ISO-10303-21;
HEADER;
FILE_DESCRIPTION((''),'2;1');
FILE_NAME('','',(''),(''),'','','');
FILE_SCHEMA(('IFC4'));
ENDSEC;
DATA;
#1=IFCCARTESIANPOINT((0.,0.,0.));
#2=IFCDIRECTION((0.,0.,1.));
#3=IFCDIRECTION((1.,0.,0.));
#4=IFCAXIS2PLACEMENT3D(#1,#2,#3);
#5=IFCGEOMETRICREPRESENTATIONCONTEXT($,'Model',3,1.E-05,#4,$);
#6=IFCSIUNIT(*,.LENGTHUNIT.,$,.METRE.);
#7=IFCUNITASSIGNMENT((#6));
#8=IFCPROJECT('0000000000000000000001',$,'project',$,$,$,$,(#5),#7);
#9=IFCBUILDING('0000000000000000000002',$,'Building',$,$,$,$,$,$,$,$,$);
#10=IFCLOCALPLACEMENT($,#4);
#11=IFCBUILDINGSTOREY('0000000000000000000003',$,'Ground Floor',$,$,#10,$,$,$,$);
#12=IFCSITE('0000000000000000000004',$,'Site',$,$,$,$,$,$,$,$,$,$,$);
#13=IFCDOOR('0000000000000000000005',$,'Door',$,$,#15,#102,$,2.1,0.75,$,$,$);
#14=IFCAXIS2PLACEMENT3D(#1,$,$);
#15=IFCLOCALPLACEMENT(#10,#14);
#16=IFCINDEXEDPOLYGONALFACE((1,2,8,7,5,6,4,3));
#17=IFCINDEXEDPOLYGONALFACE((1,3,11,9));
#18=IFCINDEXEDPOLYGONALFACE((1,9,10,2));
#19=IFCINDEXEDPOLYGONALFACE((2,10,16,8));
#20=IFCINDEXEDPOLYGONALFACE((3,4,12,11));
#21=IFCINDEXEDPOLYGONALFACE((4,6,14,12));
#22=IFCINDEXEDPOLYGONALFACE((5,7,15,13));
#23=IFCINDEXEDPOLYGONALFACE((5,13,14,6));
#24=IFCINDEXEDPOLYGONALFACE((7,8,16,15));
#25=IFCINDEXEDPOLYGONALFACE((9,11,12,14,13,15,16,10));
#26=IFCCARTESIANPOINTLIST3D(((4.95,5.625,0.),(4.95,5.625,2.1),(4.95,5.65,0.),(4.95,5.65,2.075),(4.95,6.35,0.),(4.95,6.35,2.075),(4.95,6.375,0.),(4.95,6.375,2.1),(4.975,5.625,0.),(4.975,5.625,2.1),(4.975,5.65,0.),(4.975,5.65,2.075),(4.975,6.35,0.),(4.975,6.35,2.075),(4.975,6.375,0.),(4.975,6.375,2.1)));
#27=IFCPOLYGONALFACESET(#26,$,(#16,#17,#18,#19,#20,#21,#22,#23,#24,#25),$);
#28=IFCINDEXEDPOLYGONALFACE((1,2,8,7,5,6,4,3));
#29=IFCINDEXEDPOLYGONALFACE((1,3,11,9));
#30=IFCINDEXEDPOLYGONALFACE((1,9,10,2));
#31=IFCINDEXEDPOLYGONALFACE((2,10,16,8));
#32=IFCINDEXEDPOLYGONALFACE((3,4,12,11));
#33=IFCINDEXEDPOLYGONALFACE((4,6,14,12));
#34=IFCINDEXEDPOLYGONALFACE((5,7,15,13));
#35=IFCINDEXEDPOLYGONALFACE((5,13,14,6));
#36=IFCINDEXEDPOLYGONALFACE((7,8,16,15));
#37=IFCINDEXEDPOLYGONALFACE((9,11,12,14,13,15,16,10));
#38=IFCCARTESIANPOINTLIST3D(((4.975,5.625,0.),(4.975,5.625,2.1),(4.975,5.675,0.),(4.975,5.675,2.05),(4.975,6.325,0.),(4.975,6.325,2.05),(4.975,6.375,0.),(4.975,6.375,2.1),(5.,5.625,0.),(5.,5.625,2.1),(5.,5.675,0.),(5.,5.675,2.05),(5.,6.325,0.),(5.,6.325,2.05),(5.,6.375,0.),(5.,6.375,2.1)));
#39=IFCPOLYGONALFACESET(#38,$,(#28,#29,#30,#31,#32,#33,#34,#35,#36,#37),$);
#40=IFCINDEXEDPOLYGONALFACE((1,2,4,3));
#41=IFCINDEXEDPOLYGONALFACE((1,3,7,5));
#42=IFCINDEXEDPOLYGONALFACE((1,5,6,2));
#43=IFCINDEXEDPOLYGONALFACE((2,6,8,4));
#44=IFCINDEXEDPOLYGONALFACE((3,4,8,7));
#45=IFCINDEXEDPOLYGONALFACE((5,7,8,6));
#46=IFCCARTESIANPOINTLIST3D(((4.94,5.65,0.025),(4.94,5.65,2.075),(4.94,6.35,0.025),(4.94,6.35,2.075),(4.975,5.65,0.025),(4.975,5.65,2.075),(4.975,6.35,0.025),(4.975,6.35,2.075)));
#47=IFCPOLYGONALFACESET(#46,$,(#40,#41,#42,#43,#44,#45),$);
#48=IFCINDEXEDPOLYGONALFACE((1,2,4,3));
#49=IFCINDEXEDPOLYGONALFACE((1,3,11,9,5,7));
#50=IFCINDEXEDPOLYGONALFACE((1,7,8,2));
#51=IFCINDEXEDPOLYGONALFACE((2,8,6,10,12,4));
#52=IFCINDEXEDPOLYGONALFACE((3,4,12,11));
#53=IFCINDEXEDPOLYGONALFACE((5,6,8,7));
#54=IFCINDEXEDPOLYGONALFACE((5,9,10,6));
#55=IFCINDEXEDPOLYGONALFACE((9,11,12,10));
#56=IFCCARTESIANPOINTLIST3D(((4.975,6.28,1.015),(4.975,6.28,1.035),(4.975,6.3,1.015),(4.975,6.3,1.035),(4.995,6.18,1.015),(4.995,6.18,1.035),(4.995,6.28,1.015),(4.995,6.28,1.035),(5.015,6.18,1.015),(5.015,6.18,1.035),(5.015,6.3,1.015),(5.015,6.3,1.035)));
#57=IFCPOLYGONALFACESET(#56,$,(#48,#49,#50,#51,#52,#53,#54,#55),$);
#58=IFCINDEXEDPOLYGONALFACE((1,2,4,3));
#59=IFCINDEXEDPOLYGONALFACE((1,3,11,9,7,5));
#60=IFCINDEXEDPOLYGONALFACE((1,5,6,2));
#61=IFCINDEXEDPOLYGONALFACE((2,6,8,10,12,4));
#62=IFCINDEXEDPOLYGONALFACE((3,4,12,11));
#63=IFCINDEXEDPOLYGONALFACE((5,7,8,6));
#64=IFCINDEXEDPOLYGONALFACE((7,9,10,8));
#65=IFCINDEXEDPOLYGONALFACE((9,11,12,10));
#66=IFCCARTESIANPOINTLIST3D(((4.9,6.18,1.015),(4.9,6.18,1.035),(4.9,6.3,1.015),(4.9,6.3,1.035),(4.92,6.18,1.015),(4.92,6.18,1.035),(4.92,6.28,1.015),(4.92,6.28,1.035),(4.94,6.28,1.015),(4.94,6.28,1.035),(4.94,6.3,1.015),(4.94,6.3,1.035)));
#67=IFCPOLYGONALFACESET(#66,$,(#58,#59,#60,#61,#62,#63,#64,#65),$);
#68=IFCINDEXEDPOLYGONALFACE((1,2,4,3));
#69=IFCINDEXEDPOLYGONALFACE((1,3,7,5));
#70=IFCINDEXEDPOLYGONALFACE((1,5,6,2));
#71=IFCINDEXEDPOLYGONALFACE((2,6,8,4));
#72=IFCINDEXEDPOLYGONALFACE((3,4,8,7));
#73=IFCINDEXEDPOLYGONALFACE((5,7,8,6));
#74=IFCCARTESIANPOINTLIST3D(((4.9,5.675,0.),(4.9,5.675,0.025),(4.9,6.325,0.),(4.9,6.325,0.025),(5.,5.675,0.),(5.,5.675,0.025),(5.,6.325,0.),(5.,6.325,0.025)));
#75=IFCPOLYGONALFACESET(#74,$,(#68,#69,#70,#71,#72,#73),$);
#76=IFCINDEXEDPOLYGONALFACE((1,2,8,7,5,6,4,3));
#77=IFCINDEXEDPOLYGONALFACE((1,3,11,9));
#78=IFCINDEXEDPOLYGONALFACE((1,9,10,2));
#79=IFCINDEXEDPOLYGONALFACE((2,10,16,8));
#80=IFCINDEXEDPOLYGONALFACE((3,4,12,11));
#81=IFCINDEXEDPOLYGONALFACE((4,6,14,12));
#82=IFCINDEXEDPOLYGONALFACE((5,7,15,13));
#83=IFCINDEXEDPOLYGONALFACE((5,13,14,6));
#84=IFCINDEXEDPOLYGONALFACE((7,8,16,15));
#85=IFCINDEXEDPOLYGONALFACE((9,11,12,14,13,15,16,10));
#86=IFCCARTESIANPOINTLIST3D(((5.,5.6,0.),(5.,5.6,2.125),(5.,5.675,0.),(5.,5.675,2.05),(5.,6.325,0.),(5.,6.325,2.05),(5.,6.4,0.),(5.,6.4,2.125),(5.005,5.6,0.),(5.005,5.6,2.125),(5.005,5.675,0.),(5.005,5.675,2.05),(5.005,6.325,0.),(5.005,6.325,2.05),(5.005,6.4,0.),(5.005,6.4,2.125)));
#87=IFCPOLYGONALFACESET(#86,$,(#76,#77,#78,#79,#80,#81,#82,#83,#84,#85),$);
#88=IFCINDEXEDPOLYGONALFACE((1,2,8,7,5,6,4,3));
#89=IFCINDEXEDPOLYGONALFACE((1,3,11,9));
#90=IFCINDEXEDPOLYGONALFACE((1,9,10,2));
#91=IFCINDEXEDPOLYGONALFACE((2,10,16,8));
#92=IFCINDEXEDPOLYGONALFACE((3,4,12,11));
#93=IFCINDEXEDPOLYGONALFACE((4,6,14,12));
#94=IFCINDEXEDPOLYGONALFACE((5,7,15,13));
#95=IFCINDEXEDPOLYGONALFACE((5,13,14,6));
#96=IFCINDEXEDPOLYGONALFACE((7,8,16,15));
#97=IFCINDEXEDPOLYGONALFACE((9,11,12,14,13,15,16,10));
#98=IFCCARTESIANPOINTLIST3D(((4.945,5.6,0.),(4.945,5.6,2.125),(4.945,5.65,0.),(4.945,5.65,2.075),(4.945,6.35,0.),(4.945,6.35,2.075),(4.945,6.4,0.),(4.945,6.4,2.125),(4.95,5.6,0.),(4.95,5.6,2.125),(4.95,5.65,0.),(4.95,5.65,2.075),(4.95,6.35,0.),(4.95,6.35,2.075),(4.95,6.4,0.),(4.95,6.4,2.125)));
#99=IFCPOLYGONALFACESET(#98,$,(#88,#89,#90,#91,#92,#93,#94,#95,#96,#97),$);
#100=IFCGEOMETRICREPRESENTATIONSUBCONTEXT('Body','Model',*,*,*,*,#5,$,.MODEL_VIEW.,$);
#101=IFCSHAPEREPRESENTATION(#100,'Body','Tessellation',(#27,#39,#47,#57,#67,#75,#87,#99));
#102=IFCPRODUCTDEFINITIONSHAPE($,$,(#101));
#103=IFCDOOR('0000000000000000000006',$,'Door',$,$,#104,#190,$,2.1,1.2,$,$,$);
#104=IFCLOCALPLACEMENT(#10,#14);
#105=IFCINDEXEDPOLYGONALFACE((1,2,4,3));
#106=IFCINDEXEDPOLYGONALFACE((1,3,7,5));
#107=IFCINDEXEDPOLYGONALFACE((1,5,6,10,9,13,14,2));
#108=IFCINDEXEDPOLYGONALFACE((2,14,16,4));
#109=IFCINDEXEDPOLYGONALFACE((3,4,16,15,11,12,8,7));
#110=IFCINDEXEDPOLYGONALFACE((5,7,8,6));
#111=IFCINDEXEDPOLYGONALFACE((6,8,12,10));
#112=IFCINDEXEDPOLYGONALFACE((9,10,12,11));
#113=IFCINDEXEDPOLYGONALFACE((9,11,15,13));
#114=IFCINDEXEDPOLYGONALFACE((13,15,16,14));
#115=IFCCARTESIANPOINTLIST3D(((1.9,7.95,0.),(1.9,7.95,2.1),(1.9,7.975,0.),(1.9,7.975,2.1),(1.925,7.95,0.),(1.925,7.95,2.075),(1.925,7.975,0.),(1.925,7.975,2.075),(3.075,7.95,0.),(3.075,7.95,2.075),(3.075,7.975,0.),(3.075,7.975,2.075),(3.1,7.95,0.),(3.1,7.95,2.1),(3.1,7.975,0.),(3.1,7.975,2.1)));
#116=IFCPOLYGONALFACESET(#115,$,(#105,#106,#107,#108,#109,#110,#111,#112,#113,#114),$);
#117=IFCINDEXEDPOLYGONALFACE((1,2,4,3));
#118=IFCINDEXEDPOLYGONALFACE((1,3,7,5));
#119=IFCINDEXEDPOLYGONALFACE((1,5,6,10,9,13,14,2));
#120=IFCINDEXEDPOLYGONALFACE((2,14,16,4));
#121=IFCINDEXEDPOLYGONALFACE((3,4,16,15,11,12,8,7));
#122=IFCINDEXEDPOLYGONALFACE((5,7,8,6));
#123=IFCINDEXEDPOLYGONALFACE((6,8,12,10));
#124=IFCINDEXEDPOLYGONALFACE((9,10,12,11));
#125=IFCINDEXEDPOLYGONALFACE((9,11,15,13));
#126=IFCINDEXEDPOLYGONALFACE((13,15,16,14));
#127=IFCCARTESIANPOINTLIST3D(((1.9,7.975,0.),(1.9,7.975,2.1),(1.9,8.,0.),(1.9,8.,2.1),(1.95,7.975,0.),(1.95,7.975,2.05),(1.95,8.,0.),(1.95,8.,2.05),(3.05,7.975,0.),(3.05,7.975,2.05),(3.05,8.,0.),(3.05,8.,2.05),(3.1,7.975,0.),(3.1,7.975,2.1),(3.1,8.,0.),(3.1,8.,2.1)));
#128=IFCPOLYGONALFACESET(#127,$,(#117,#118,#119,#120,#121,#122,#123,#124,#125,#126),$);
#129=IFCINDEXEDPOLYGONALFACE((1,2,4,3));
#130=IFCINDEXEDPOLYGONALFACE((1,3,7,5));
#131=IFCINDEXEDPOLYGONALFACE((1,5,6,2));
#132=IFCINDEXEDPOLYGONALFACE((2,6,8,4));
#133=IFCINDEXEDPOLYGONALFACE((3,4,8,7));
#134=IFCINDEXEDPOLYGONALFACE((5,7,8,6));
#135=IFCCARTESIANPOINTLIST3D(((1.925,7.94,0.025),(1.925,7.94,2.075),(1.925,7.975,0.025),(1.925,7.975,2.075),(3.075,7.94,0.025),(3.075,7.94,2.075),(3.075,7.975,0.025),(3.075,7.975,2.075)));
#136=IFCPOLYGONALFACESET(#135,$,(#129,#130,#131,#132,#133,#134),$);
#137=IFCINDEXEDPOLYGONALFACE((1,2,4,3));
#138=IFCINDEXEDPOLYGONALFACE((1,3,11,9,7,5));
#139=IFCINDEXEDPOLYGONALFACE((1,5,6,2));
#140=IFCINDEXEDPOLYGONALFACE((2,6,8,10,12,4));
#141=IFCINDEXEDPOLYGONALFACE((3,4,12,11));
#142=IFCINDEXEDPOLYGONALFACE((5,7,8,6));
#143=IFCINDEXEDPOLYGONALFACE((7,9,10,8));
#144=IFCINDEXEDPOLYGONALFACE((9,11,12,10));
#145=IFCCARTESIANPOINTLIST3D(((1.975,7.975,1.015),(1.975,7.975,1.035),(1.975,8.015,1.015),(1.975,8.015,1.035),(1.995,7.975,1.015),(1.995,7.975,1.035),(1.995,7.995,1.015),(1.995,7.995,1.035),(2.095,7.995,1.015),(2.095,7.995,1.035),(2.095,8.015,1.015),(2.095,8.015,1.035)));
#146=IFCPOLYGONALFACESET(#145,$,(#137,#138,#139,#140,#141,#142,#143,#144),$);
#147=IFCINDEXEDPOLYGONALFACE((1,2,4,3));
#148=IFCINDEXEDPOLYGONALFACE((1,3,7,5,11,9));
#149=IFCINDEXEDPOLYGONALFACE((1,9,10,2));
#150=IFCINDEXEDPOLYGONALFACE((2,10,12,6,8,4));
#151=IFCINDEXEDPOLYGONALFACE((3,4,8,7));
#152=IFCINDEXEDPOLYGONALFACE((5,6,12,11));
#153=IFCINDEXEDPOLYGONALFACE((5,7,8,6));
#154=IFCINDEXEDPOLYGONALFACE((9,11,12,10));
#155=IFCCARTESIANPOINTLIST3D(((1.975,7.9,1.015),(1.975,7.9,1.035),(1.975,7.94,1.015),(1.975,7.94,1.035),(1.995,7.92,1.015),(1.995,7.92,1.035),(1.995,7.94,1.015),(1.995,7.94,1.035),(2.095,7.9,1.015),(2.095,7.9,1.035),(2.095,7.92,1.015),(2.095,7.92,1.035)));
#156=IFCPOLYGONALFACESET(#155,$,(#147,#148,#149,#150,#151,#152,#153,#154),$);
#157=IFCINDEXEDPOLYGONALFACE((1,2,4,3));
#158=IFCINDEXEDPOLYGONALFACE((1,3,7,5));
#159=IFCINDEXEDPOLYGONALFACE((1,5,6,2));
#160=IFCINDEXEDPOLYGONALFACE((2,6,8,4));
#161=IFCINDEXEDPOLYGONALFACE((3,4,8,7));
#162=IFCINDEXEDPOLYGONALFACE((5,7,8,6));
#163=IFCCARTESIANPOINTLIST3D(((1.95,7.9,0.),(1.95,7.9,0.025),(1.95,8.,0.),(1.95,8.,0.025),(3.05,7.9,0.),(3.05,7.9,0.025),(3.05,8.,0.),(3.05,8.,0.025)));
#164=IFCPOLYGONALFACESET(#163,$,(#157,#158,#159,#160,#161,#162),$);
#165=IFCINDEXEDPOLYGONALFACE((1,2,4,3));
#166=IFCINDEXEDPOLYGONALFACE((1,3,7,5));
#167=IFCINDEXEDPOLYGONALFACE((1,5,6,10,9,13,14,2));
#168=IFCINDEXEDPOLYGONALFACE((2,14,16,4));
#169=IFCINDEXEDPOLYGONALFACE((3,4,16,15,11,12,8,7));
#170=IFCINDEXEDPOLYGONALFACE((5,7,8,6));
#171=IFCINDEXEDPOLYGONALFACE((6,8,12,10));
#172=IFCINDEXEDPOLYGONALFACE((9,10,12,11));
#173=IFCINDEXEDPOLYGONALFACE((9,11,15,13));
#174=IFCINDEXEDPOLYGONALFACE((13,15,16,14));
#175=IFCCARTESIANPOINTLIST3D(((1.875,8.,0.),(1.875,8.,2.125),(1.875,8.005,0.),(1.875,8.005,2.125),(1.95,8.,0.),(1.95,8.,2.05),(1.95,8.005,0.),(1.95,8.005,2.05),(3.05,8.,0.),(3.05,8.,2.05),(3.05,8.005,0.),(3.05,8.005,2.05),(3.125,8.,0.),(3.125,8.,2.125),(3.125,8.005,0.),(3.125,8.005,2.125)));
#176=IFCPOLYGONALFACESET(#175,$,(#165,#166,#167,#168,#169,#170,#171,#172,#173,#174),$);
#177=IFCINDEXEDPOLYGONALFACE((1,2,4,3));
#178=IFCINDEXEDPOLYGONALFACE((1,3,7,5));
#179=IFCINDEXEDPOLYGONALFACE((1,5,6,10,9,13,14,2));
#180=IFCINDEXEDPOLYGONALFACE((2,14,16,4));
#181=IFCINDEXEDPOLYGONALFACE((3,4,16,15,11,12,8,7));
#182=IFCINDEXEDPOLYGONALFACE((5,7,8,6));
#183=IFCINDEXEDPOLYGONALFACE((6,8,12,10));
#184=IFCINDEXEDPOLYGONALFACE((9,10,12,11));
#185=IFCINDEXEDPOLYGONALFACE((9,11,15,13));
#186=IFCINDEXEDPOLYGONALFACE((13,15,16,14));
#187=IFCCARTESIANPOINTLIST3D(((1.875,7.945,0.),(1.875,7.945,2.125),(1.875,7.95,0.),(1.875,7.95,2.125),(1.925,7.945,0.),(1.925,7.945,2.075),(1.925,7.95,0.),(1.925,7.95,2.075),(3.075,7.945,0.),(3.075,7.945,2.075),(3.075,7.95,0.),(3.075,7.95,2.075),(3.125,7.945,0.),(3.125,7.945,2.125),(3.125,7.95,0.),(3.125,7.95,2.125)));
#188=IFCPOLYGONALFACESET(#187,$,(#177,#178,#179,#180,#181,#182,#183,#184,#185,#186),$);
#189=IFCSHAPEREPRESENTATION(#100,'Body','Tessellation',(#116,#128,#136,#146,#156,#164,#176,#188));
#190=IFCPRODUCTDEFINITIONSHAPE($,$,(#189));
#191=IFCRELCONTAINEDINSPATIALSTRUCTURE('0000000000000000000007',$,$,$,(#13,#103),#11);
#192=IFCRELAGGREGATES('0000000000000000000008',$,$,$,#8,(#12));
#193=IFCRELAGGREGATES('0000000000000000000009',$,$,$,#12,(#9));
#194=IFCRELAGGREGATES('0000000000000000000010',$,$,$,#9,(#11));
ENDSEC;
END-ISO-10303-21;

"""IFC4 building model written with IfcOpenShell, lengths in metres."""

from ifc_helpers import new_model, si_unit, frame, origin_with_axes, place, context, subcontext, project, spatial, line, indexed_curve, outline, extrude, element, save


model = new_model("IFC4")

# Units and contexts
model_context = context("Model", 3, precision=1e-05, world=origin_with_axes())
body_context = subcontext(model_context, "Body", "Model", "MODEL_VIEW")
ifc_project = project(units=[si_unit("LENGTHUNIT", "METRE")], contexts=[model_context])

# Site, building, storey
site = spatial("IfcSite", under=ifc_project, Name="Site")
building = spatial("IfcBuilding", under=site, Name="Building")
storey_placement = place(None, origin_with_axes())
storey = spatial("IfcBuildingStorey", under=building, at=storey_placement, Name="Ground Floor")

# Doors
door_1_placement = place(storey_placement, frame((5.0, 5.625, 0.0), z_axis=(0.0, 0.0, 1.0), x_axis=(0.0, 1.0, 0.0)))
element("IfcDoor", 1, at=door_1_placement, inside=storey, Name="Door", OverallHeight=2.1, OverallWidth=0.75, context=body_context, shape_type="SweptSolid", body=[
    extrude(outline(indexed_curve([(0.0, 0.0), (0.0, 2.1), (0.75, 2.1), (0.75, 0.0), (0.725, 0.0), (0.725, 2.075), (0.025, 2.075), (0.025, 0.0)], segments=[line(1, 2, 3, 4, 5, 6, 7, 8, 1)])), frame((0.0, 0.025, 0.0), z_axis=(0.0, -1.0, 0.0), x_axis=(1.0, 0.0, 0.0)), (0.0, 0.0, -1.0), 0.025),
    extrude(outline(indexed_curve([(0.0, 0.0), (0.0, 2.1), (0.75, 2.1), (0.75, 0.0), (0.7, 0.0), (0.7, 2.05), (0.05, 2.05), (0.05, 0.0)], segments=[line(1, 2, 3, 4, 5, 6, 7, 8, 1)])), frame((0.0, 0.0, 0.0), z_axis=(0.0, -1.0, 0.0), x_axis=(1.0, 0.0, 0.0)), (0.0, 0.0, -1.0), 0.025),
    extrude(outline(indexed_curve([(0.0, 0.0), (0.7, 0.0), (0.7, 0.035), (0.0, 0.035)], segments=[line(1, 2, 3, 4, 1)])), frame((0.025, 0.025, 0.025), z_axis=(0.0, 0.0, 1.0), x_axis=(1.0, 0.0, 0.0)), (0.0, 0.0, 1.0), 2.05),
    extrude(outline(indexed_curve([(0.0, 0.0), (0.0, -0.04), (-0.12, -0.04), (-0.12, -0.02), (-0.02, -0.02), (-0.02, 0.0)], segments=[line(1, 2, 3, 4, 5, 6, 1)])), frame((0.675, 0.025, 1.015), z_axis=(0.0, 0.0, 1.0), x_axis=(1.0, 0.0, 0.0)), (0.0, 0.0, 1.0), 0.02),
    extrude(outline(indexed_curve([(0.0, 0.0), (0.0, 0.04), (-0.12, 0.04), (-0.12, 0.02), (-0.02, 0.02), (-0.02, 0.0)], segments=[line(1, 2, 3, 4, 5, 6, 1)])), frame((0.675, 0.06, 1.015), z_axis=(0.0, 0.0, 1.0), x_axis=(1.0, 0.0, 0.0)), (0.0, 0.0, 1.0), 0.02),
    extrude(outline(indexed_curve([(0.0, 0.0), (0.65, 0.0), (0.65, 0.1), (0.0, 0.1)], segments=[line(1, 2, 3, 4, 1)])), frame((0.05, 0.0, 0.0), z_axis=(0.0, 0.0, 1.0), x_axis=(1.0, 0.0, 0.0)), (0.0, 0.0, 1.0), 0.025),
    extrude(outline(indexed_curve([(0.0, 0.0), (0.0, 2.125), (0.8, 2.125), (0.8, 0.0), (0.725, 0.0), (0.725, 2.05), (0.075, 2.05), (0.075, 0.0)], segments=[line(1, 2, 3, 4, 5, 6, 7, 8, 1)])), frame((-0.025, -0.005, 0.0), z_axis=(0.0, -1.0, 0.0), x_axis=(1.0, 0.0, 0.0)), (0.0, 0.0, -1.0), 0.005),
    extrude(outline(indexed_curve([(0.0, 0.0), (0.0, 2.125), (0.8, 2.125), (0.8, 0.0), (0.75, 0.0), (0.75, 2.075), (0.05, 2.075), (0.05, 0.0)], segments=[line(1, 2, 3, 4, 5, 6, 7, 8, 1)])), frame((-0.025, 0.05, 0.0), z_axis=(0.0, -1.0, 0.0), x_axis=(1.0, 0.0, 0.0)), (0.0, 0.0, -1.0), 0.005),
])
door_2_placement = place(storey_placement, frame((3.1, 8.0, 0.0), z_axis=(0.0, 0.0, 1.0), x_axis=(-1.0, 0.0, 0.0)))
element("IfcDoor", 2, at=door_2_placement, inside=storey, Name="Door", OverallHeight=2.1, OverallWidth=1.2, context=body_context, shape_type="SweptSolid", body=[
    extrude(outline(indexed_curve([(0.0, 0.0), (0.0, 2.1), (1.2, 2.1), (1.2, 0.0), (1.175, 0.0), (1.175, 2.075), (0.025, 2.075), (0.025, 0.0)], segments=[line(1, 2, 3, 4, 5, 6, 7, 8, 1)])), frame((0.0, 0.025, 0.0), z_axis=(0.0, -1.0, 0.0), x_axis=(1.0, 0.0, 0.0)), (0.0, 0.0, -1.0), 0.025),
    extrude(outline(indexed_curve([(0.0, 0.0), (0.0, 2.1), (1.2, 2.1), (1.2, 0.0), (1.15, 0.0), (1.15, 2.05), (0.05, 2.05), (0.05, 0.0)], segments=[line(1, 2, 3, 4, 5, 6, 7, 8, 1)])), frame((0.0, 0.0, 0.0), z_axis=(0.0, -1.0, 0.0), x_axis=(1.0, 0.0, 0.0)), (0.0, 0.0, -1.0), 0.025),
    extrude(outline(indexed_curve([(0.0, 0.0), (1.15, 0.0), (1.15, 0.035), (0.0, 0.035)], segments=[line(1, 2, 3, 4, 1)])), frame((0.025, 0.025, 0.025), z_axis=(0.0, 0.0, 1.0), x_axis=(1.0, 0.0, 0.0)), (0.0, 0.0, 1.0), 2.05),
    extrude(outline(indexed_curve([(0.0, 0.0), (0.0, -0.04), (-0.12, -0.04), (-0.12, -0.02), (-0.02, -0.02), (-0.02, 0.0)], segments=[line(1, 2, 3, 4, 5, 6, 1)])), frame((1.125, 0.025, 1.015), z_axis=(0.0, 0.0, 1.0), x_axis=(1.0, 0.0, 0.0)), (0.0, 0.0, 1.0), 0.02),
    extrude(outline(indexed_curve([(0.0, 0.0), (0.0, 0.04), (-0.12, 0.04), (-0.12, 0.02), (-0.02, 0.02), (-0.02, 0.0)], segments=[line(1, 2, 3, 4, 5, 6, 1)])), frame((1.125, 0.06, 1.015), z_axis=(0.0, 0.0, 1.0), x_axis=(1.0, 0.0, 0.0)), (0.0, 0.0, 1.0), 0.02),
    extrude(outline(indexed_curve([(0.0, 0.0), (1.1, 0.0), (1.1, 0.1), (0.0, 0.1)], segments=[line(1, 2, 3, 4, 1)])), frame((0.05, 0.0, 0.0), z_axis=(0.0, 0.0, 1.0), x_axis=(1.0, 0.0, 0.0)), (0.0, 0.0, 1.0), 0.025),
    extrude(outline(indexed_curve([(0.0, 0.0), (0.0, 2.125), (1.25, 2.125), (1.25, 0.0), (1.175, 0.0), (1.175, 2.05), (0.075, 2.05), (0.075, 0.0)], segments=[line(1, 2, 3, 4, 5, 6, 7, 8, 1)])), frame((-0.025, -0.005, 0.0), z_axis=(0.0, -1.0, 0.0), x_axis=(1.0, 0.0, 0.0)), (0.0, 0.0, -1.0), 0.005),
    extrude(outline(indexed_curve([(0.0, 0.0), (0.0, 2.125), (1.25, 2.125), (1.25, 0.0), (1.2, 0.0), (1.2, 2.075), (0.05, 2.075), (0.05, 0.0)], segments=[line(1, 2, 3, 4, 5, 6, 7, 8, 1)])), frame((-0.025, 0.05, 0.0), z_axis=(0.0, -1.0, 0.0), x_axis=(1.0, 0.0, 0.0)), (0.0, 0.0, -1.0), 0.005),
])

save(model, "model.ifc")
